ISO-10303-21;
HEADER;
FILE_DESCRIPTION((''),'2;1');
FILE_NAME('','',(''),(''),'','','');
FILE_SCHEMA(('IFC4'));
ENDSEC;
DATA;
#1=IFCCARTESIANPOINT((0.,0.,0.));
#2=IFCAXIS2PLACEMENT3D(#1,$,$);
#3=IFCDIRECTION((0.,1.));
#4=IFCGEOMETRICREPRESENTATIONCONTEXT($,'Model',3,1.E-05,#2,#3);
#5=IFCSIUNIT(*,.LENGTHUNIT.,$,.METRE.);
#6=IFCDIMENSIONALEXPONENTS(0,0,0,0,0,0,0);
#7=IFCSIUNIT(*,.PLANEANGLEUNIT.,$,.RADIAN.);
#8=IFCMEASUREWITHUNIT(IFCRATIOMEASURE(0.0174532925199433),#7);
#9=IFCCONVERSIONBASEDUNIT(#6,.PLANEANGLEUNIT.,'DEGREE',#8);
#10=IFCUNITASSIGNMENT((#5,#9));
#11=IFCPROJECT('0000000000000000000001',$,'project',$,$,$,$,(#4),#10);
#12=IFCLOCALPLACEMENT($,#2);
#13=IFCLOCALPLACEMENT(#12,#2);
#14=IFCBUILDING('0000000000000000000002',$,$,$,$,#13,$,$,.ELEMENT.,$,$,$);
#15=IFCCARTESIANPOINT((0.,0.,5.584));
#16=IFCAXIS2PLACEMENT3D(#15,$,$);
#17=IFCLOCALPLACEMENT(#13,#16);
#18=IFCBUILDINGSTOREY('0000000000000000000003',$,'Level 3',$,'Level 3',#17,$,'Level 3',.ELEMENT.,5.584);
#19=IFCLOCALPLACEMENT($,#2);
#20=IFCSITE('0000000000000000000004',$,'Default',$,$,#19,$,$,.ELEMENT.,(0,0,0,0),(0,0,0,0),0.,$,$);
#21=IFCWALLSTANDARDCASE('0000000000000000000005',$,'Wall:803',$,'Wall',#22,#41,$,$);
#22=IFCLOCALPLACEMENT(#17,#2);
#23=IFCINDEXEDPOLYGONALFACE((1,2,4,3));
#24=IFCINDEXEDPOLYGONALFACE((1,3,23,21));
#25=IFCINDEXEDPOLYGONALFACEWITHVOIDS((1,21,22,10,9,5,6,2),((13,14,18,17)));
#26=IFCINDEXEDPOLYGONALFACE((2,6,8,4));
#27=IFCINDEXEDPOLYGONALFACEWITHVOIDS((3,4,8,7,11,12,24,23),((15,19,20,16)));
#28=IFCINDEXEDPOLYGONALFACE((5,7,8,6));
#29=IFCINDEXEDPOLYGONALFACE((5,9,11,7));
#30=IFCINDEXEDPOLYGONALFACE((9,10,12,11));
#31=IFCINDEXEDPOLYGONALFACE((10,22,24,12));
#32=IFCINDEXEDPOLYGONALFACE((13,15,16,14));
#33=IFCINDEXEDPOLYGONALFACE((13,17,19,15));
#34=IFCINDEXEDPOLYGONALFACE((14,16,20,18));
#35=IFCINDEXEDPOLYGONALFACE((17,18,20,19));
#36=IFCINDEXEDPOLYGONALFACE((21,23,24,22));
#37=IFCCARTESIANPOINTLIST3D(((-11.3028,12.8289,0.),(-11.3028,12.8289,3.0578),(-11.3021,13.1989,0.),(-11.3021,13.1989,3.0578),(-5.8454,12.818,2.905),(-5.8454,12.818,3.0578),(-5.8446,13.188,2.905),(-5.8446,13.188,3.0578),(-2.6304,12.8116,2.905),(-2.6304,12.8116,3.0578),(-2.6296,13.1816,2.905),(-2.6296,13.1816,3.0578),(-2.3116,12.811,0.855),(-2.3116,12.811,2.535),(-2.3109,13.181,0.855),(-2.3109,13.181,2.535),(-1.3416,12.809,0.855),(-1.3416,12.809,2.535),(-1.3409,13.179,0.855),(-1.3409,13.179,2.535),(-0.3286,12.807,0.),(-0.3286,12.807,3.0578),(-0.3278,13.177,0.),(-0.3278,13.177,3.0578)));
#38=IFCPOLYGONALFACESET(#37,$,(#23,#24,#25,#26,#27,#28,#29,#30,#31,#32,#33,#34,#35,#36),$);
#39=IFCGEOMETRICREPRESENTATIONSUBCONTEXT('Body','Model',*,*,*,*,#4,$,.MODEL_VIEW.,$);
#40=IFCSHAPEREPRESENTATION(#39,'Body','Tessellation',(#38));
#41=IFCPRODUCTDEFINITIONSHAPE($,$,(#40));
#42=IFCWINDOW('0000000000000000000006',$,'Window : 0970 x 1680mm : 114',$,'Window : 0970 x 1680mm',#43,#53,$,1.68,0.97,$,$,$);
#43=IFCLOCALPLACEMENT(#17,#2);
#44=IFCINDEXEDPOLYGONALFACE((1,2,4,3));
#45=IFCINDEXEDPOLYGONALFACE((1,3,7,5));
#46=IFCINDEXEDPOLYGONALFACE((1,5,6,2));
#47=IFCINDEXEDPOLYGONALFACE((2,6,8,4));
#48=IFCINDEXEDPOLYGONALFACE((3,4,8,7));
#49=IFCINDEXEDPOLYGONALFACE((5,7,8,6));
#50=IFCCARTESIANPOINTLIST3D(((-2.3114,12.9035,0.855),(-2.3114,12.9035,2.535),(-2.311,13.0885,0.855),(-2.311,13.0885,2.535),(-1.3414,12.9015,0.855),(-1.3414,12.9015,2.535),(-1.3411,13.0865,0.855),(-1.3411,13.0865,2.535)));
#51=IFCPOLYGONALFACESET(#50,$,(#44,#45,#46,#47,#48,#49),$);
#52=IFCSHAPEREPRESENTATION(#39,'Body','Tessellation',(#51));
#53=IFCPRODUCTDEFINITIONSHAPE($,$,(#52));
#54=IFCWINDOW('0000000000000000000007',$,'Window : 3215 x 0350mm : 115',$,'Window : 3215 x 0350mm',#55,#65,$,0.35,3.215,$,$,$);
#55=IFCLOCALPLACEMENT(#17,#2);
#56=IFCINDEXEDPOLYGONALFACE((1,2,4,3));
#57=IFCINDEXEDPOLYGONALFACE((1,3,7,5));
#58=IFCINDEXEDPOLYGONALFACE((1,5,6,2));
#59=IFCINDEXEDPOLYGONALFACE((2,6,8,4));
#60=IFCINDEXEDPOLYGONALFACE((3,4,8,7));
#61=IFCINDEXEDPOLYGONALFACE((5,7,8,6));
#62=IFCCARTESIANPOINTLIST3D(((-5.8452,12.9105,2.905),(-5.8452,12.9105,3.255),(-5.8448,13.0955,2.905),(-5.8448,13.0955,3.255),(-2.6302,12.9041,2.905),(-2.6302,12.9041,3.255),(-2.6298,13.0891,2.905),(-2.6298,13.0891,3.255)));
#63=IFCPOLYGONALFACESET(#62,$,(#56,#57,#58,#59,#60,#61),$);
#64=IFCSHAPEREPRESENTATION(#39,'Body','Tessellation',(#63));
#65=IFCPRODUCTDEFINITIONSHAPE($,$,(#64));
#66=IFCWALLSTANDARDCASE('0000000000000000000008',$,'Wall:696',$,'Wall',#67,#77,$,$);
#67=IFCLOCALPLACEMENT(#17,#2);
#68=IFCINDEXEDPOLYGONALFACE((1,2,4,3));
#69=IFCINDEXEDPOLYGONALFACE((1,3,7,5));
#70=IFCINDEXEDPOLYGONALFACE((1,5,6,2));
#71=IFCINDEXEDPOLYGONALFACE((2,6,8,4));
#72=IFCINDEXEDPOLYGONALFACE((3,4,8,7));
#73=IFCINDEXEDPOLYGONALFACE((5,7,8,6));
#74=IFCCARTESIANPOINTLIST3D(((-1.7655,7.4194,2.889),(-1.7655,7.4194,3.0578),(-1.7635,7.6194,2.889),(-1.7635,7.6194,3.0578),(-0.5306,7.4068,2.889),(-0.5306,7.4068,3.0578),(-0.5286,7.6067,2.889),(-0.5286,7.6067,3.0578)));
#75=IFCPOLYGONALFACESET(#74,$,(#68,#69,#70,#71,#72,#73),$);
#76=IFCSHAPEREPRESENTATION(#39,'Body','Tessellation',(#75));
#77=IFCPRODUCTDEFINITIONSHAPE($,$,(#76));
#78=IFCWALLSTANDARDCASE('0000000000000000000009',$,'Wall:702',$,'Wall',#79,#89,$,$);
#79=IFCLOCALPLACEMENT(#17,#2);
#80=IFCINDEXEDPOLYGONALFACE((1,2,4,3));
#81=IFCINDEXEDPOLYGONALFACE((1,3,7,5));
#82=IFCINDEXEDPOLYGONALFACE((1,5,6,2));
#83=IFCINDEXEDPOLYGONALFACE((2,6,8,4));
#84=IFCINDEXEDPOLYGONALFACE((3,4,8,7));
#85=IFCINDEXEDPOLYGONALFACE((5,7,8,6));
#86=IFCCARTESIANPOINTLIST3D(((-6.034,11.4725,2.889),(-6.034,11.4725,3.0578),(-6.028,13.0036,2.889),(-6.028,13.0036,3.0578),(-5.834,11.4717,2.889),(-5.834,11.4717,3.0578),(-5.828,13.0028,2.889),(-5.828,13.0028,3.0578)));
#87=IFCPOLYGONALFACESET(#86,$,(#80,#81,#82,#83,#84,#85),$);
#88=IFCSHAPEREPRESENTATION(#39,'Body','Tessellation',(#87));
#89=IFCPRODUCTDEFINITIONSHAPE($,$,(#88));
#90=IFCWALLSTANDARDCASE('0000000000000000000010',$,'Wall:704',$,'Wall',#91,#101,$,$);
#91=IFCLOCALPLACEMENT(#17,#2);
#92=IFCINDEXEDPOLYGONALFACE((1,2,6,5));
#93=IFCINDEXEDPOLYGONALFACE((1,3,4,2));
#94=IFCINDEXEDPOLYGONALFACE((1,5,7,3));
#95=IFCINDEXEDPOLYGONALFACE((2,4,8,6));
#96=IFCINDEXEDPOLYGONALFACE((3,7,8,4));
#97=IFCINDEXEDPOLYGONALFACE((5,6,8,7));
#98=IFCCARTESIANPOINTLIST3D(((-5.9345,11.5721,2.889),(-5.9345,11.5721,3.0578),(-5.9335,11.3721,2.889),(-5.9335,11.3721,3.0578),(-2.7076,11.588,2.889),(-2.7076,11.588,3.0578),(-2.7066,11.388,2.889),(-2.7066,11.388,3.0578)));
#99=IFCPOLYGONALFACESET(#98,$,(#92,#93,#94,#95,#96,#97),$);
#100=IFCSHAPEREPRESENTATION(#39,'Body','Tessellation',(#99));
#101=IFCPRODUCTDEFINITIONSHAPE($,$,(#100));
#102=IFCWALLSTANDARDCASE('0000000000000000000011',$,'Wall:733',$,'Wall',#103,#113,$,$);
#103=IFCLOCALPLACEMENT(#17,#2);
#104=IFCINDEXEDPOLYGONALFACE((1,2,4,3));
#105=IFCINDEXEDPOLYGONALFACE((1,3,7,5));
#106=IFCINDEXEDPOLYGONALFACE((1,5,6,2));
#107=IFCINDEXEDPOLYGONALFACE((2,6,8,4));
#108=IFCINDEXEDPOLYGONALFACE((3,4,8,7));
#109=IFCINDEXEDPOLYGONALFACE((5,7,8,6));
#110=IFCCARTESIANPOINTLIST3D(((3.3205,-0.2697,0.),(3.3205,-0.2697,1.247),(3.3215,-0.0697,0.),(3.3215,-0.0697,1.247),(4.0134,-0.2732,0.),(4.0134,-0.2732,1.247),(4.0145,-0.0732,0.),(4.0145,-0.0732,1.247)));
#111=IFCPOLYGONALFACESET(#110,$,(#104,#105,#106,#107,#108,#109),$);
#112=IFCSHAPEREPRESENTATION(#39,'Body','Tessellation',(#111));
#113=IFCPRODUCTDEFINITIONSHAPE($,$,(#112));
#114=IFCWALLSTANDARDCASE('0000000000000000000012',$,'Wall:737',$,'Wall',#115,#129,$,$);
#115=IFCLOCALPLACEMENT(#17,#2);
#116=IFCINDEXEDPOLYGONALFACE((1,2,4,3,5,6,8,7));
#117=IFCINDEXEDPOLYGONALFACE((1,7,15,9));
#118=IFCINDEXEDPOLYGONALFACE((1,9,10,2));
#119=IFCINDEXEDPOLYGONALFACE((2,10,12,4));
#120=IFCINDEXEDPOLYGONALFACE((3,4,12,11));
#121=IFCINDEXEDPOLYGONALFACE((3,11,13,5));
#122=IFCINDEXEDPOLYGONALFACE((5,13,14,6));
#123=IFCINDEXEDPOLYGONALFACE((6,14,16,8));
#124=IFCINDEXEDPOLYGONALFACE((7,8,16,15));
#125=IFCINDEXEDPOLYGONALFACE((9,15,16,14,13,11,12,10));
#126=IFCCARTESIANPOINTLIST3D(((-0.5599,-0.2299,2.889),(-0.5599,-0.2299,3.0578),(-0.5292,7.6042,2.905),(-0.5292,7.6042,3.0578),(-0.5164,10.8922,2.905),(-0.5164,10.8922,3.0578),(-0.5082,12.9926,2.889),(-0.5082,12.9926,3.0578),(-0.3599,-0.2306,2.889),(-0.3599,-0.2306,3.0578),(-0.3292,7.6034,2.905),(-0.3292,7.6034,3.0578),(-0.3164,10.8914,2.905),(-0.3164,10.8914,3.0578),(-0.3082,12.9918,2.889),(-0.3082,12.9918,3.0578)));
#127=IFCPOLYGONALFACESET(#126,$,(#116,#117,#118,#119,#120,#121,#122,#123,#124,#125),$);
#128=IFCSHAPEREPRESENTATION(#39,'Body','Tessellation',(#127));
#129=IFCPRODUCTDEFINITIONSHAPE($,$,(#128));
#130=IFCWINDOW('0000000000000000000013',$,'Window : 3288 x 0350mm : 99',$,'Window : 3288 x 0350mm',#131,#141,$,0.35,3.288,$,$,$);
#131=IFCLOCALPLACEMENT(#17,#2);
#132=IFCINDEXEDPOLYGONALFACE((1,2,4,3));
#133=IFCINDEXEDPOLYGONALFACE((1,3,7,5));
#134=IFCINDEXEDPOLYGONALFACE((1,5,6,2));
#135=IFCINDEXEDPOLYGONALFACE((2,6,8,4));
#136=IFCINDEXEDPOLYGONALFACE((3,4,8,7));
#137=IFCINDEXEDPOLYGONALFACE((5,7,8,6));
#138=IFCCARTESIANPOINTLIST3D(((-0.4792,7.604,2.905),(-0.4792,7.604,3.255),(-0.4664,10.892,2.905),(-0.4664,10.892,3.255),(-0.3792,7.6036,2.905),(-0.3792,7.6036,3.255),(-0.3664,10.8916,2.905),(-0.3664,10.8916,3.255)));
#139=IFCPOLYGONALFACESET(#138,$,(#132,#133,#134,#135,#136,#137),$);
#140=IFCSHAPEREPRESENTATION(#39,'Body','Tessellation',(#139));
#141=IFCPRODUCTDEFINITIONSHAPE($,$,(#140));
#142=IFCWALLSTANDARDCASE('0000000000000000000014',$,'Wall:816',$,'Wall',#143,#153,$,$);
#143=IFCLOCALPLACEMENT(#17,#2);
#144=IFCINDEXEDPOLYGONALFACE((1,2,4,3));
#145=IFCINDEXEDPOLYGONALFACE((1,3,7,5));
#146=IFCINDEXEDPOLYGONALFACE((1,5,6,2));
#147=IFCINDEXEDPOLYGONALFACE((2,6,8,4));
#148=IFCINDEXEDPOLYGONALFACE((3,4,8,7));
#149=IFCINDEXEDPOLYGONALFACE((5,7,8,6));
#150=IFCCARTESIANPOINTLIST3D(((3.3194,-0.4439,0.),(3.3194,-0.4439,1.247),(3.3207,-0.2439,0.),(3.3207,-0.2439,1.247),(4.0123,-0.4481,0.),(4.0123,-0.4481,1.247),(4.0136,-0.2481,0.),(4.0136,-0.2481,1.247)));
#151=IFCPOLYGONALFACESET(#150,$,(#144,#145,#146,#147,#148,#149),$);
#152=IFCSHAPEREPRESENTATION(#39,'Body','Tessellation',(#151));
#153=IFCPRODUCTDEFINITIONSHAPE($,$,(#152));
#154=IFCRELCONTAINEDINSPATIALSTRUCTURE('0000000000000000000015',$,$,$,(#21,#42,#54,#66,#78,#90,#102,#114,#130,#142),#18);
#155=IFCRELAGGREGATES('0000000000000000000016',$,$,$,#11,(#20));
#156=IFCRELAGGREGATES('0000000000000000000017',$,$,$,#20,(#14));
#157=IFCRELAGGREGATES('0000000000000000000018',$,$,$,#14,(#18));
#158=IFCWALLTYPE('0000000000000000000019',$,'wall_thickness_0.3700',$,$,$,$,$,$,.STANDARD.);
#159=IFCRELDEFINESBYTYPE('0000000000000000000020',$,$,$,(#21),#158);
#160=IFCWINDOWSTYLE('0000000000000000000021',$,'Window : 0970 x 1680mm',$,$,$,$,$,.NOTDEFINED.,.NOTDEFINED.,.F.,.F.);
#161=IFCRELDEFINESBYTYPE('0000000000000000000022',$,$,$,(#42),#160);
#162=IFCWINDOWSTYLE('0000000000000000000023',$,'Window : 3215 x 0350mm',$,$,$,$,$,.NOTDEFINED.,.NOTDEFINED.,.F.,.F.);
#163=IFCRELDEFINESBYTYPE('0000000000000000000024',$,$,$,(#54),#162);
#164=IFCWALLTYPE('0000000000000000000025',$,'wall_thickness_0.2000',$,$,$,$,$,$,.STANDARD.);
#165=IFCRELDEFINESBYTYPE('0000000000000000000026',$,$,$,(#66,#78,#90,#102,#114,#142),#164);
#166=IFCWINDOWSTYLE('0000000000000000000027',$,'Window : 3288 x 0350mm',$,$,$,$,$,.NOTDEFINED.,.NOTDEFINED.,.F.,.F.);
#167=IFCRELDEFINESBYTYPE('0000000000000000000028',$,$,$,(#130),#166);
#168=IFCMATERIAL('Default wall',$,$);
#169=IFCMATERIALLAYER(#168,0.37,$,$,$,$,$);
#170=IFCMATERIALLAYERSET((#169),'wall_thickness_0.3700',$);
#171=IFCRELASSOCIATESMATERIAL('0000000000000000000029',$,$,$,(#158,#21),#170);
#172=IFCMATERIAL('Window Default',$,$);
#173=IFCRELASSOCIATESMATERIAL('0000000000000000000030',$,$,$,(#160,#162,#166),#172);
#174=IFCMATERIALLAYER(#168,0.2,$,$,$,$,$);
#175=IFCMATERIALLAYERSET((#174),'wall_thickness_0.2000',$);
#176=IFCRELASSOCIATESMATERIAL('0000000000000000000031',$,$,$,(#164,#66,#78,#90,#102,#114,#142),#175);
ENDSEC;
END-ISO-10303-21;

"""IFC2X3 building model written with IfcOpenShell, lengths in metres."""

from ifc_helpers import new_model, entity, si_unit, converted_unit, direction, frame, frame_2d, origin, origin_2d_with_axis, place, context, subcontext, project, spatial, polyline, rectangle, outline, extrude, source, transform, mapped, material, layer, layer_set, layer_usage, type_object, type_shapes, element, fill, save


model = new_model("IFC2X3")

# Units and contexts
model_context = context("Model", 3, precision=1e-05, world=origin(), true_north=direction((0.0, 1.0)))
body_context = subcontext(model_context, "Body", "Model", "MODEL_VIEW")
ifc_project = project(units=[si_unit("LENGTHUNIT", "METRE"), converted_unit("PLANEANGLEUNIT", "DEGREE", entity("IfcRatioMeasure", 0.0174532925199433), si_unit("PLANEANGLEUNIT", "RADIAN"), dimensions=[0, 0, 0, 0, 0, 0, 0])], contexts=[model_context])

# Site, building, storey
site_placement = place(None, origin())
site = spatial("IfcSite", under=ifc_project, at=site_placement, Name="Default", CompositionType="ELEMENT", RefLatitude=(0, 0, 0, 0), RefLongitude=(0, 0, 0, 0), RefElevation=0.0)
placement_1 = place(None, origin())
building_placement = place(placement_1, origin())
building = spatial("IfcBuilding", under=site, at=building_placement, CompositionType="ELEMENT")
storey_placement = place(building_placement, frame((0.0, 0.0, 5.584)))
storey = spatial("IfcBuildingStorey", under=building, at=storey_placement, Name="Level 3", ObjectType="Level 3", LongName="Level 3", CompositionType="ELEMENT", Elevation=5.584)

# Wall, openings, windows
ifc_material_1 = material(Name="Default wall")
ifc_layer_1 = layer(ifc_material_1, 0.37)
ifc_layer_set_1 = layer_set([ifc_layer_1], Name="wall_thickness_0.3700")
ifc_layer_usage_1 = layer_usage(ifc_layer_set_1, "AXIS2", "POSITIVE", -0.185)
wall_type_1 = type_object("IfcWallType", Name="wall_thickness_0.3700", PredefinedType="STANDARD", material=ifc_layer_set_1)
wall_1_placement = place(storey_placement, frame((-11.3025, 13.0139, 0.0), z_axis=(0.0, 0.0, 1.0), x_axis=(0.999998, -0.001992, 0.0)))
wall_1 = element("IfcWallStandardCase", 1, at=wall_1_placement, inside=storey, type_object=wall_type_1, material=ifc_layer_usage_1, Name="Wall:803", ObjectType="Wall", context=body_context, shape_type="SweptSolid", body=[
    extrude(outline(polyline([(10.9743, -0.185), (10.9743, 0.185), (0.0, 0.185), (0.0, -0.185), (10.9743, -0.185)])), origin(), (0.0, 0.0, 1.0), 3.0578),
])
opening_1_placement = place(wall_1_placement, frame((8.9912, -0.185, 0.855)))
opening_1 = element("IfcOpeningElement", 2, at=opening_1_placement, cuts=wall_1, ObjectType="Opening", context=body_context, shape_type="SweptSolid", body=[
    extrude(rectangle(XDim=0.97, YDim=1.68, at=frame_2d((0.84, 0.485), x_axis=(0.0, 1.0))), frame((0.0, 0.0, 0.0), z_axis=(0.0, 1.0, 0.0), x_axis=(0.0, 0.0, 1.0)), (0.0, 0.0, 1.0), 0.37),
])
opening_2_placement = place(wall_1_placement, frame((5.4575, -0.185, 2.905)))
opening_2 = element("IfcOpeningElement", 3, at=opening_2_placement, cuts=wall_1, ObjectType="Opening", context=body_context, shape_type="SweptSolid", body=[
    extrude(rectangle(XDim=3.215, YDim=0.35, at=frame_2d((0.175, 1.6075), x_axis=(0.0, 1.0))), frame((0.0, 0.0, 0.0), z_axis=(0.0, 1.0, 0.0), x_axis=(0.0, 0.0, 1.0)), (0.0, 0.0, 1.0), 0.37),
])
ifc_material_2 = material(Name="Window Default")
window_style_1 = type_object("IfcWindowStyle", Name="Window : 0970 x 1680mm", ConstructionType="NOTDEFINED", OperationType="NOTDEFINED", ParameterTakesPrecedence=False, Sizeable=False, material=ifc_material_2)
shared_shape_1 = source(origin(), body_context, "Body", "SweptSolid", [
    extrude(rectangle(XDim=0.185, YDim=0.97, at=origin_2d_with_axis()), frame((0.485, 0.185, 0.0), z_axis=(0.0, 0.0, 1.0), x_axis=(0.0, 1.0, 0.0)), (0.0, 0.0, 1.0), 1.68),
])
type_shapes(window_style_1, [shared_shape_1])
window_1_placement = place(opening_1_placement, origin())
window_1 = element("IfcWindow", 4, at=window_1_placement, inside=storey, type_object=window_style_1, Name="Window : 0970 x 1680mm : 114", ObjectType="Window : 0970 x 1680mm", OverallHeight=1.68, OverallWidth=0.97, context=body_context, shape_type="MappedRepresentation", body=[
    mapped(shared_shape_1, transform((0.0, 0.0, 0.0), scale=1.0)),
])
fill(opening_1, window_1)
window_style_2 = type_object("IfcWindowStyle", Name="Window : 3215 x 0350mm", ConstructionType="NOTDEFINED", OperationType="NOTDEFINED", ParameterTakesPrecedence=False, Sizeable=False, material=ifc_material_2)
shared_shape_2 = source(origin(), body_context, "Body", "SweptSolid", [
    extrude(rectangle(XDim=0.185, YDim=3.215, at=origin_2d_with_axis()), frame((1.6075, 0.185, 0.0), z_axis=(0.0, 0.0, 1.0), x_axis=(0.0, 1.0, 0.0)), (0.0, 0.0, 1.0), 0.35),
])
type_shapes(window_style_2, [shared_shape_2])
window_2_placement = place(opening_2_placement, origin())
window_2 = element("IfcWindow", 5, at=window_2_placement, inside=storey, type_object=window_style_2, Name="Window : 3215 x 0350mm : 115", ObjectType="Window : 3215 x 0350mm", OverallHeight=0.35, OverallWidth=3.215, context=body_context, shape_type="MappedRepresentation", body=[
    mapped(shared_shape_2, transform((0.0, 0.0, 0.0), scale=1.0)),
])
fill(opening_2, window_2)

# Walls
ifc_layer_2 = layer(ifc_material_1, 0.2)
ifc_layer_set_2 = layer_set([ifc_layer_2], Name="wall_thickness_0.2000")
ifc_layer_usage_2 = layer_usage(ifc_layer_set_2, "AXIS2", "POSITIVE", -0.1)
wall_type_2 = type_object("IfcWallType", Name="wall_thickness_0.2000", PredefinedType="STANDARD", material=ifc_layer_set_2)
placement_2 = place(building_placement, frame((0.0, 0.0, 8.473)))
wall_2_placement = place(placement_2, frame((-1.7645, 7.5194, 0.0), z_axis=(0.0, 0.0, 1.0), x_axis=(0.999948, -0.010217, 0.0)))
element("IfcWallStandardCase", 6, at=wall_2_placement, inside=storey, type_object=wall_type_2, material=ifc_layer_usage_2, Name="Wall:696", ObjectType="Wall", context=body_context, shape_type="SweptSolid", body=[
    extrude(outline(polyline([(1.235, -0.1), (1.235, 0.1), (0.0, 0.1), (0.0, -0.1), (1.235, -0.1)])), origin(), (0.0, 0.0, 1.0), 0.1688),
])
placement_3 = place(building_placement, frame((0.0, 0.0, 8.473)))
wall_3_placement = place(placement_3, frame((-5.934, 11.4721, 0.0), z_axis=(0.0, 0.0, 1.0), x_axis=(0.003893, 0.999992, 0.0)))
element("IfcWallStandardCase", 7, at=wall_3_placement, inside=storey, type_object=wall_type_2, material=ifc_layer_usage_2, Name="Wall:702", ObjectType="Wall", context=body_context, shape_type="SweptSolid", body=[
    extrude(outline(polyline([(1.5311, -0.1), (1.5311, 0.1), (0.0, 0.1), (0.0, -0.1), (1.5311, -0.1)])), origin(), (0.0, 0.0, 1.0), 0.1688),
])
placement_4 = place(building_placement, frame((0.0, 0.0, 8.473)))
wall_4_placement = place(placement_4, frame((-5.934, 11.4721, 0.0), z_axis=(0.0, 0.0, 1.0), x_axis=(0.999988, 0.004936, 0.0)))
element("IfcWallStandardCase", 8, at=wall_4_placement, inside=storey, type_object=wall_type_2, material=ifc_layer_usage_2, Name="Wall:704", ObjectType="Wall", context=body_context, shape_type="SweptSolid", body=[
    extrude(outline(polyline([(3.2269, -0.1), (3.2269, 0.1), (0.0, 0.1), (0.0, -0.1), (3.2269, -0.1)])), origin(), (0.0, 0.0, 1.0), 0.1688),
])
wall_5_placement = place(storey_placement, frame((3.321, -0.1697, 0.0), z_axis=(0.0, 0.0, 1.0), x_axis=(0.999987, -0.005138, 0.0)))
element("IfcWallStandardCase", 9, at=wall_5_placement, inside=storey, type_object=wall_type_2, material=ifc_layer_usage_2, Name="Wall:733", ObjectType="Wall", context=body_context, shape_type="SweptSolid", body=[
    extrude(outline(polyline([(0.693, -0.1), (0.693, 0.1), (0.0, 0.1), (0.0, -0.1), (0.693, -0.1)])), origin(), (0.0, 0.0, 1.0), 1.247),
])

# Wall, opening, window
placement_5 = place(building_placement, frame((0.0, 0.0, 8.473)))
wall_6_placement = place(placement_5, frame((-0.4082, 12.9922, 0.0), z_axis=(0.0, 0.0, 1.0), x_axis=(-0.003909, -0.999992, 0.0)))
wall_6 = element("IfcWallStandardCase", 10, at=wall_6_placement, inside=storey, type_object=wall_type_2, material=ifc_layer_usage_2, Name="Wall:737", ObjectType="Wall", context=body_context, shape_type="SweptSolid", body=[
    extrude(outline(polyline([(13.2225, -0.1), (13.2225, 0.1), (0.0, 0.1), (0.0, -0.1), (13.2225, -0.1)])), origin(), (0.0, 0.0, 1.0), 0.1688),
])
opening_3_placement = place(wall_6_placement, frame((2.1004, -0.1, 0.016)))
opening_3 = element("IfcOpeningElement", 11, at=opening_3_placement, cuts=wall_6, ObjectType="Opening", context=body_context, shape_type="SweptSolid", body=[
    extrude(rectangle(XDim=3.288, YDim=0.35, at=frame_2d((0.175, 1.644), x_axis=(0.0, 1.0))), frame((0.0, 0.0, 0.0), z_axis=(0.0, 1.0, 0.0), x_axis=(0.0, 0.0, 1.0)), (0.0, 0.0, 1.0), 0.2),
])
window_style_3 = type_object("IfcWindowStyle", Name="Window : 3288 x 0350mm", ConstructionType="NOTDEFINED", OperationType="NOTDEFINED", ParameterTakesPrecedence=False, Sizeable=False, material=ifc_material_2)
shared_shape_3 = source(origin(), body_context, "Body", "SweptSolid", [
    extrude(rectangle(XDim=0.1, YDim=3.288, at=origin_2d_with_axis()), frame((1.644, 0.1, 0.0), z_axis=(0.0, 0.0, 1.0), x_axis=(0.0, 1.0, 0.0)), (0.0, 0.0, 1.0), 0.35),
])
type_shapes(window_style_3, [shared_shape_3])
window_3_placement = place(opening_3_placement, origin())
window_3 = element("IfcWindow", 12, at=window_3_placement, inside=storey, type_object=window_style_3, Name="Window : 3288 x 0350mm : 99", ObjectType="Window : 3288 x 0350mm", OverallHeight=0.35, OverallWidth=3.288, context=body_context, shape_type="MappedRepresentation", body=[
    mapped(shared_shape_3, transform((0.0, 0.0, 0.0), scale=1.0)),
])
fill(opening_3, window_3)

# Wall
wall_7_placement = place(storey_placement, frame((3.32, -0.3439, 0.0), z_axis=(0.0, 0.0, 1.0), x_axis=(0.999981, -0.006147, 0.0)))
element("IfcWallStandardCase", 13, at=wall_7_placement, inside=storey, type_object=wall_type_2, material=ifc_layer_usage_2, Name="Wall:816", ObjectType="Wall", context=body_context, shape_type="SweptSolid", body=[
    extrude(outline(polyline([(0.6929, -0.1), (0.6929, 0.1), (0.0, 0.1), (0.0, -0.1), (0.6929, -0.1)])), origin(), (0.0, 0.0, 1.0), 1.247),
])

save(model, "model.ifc")
